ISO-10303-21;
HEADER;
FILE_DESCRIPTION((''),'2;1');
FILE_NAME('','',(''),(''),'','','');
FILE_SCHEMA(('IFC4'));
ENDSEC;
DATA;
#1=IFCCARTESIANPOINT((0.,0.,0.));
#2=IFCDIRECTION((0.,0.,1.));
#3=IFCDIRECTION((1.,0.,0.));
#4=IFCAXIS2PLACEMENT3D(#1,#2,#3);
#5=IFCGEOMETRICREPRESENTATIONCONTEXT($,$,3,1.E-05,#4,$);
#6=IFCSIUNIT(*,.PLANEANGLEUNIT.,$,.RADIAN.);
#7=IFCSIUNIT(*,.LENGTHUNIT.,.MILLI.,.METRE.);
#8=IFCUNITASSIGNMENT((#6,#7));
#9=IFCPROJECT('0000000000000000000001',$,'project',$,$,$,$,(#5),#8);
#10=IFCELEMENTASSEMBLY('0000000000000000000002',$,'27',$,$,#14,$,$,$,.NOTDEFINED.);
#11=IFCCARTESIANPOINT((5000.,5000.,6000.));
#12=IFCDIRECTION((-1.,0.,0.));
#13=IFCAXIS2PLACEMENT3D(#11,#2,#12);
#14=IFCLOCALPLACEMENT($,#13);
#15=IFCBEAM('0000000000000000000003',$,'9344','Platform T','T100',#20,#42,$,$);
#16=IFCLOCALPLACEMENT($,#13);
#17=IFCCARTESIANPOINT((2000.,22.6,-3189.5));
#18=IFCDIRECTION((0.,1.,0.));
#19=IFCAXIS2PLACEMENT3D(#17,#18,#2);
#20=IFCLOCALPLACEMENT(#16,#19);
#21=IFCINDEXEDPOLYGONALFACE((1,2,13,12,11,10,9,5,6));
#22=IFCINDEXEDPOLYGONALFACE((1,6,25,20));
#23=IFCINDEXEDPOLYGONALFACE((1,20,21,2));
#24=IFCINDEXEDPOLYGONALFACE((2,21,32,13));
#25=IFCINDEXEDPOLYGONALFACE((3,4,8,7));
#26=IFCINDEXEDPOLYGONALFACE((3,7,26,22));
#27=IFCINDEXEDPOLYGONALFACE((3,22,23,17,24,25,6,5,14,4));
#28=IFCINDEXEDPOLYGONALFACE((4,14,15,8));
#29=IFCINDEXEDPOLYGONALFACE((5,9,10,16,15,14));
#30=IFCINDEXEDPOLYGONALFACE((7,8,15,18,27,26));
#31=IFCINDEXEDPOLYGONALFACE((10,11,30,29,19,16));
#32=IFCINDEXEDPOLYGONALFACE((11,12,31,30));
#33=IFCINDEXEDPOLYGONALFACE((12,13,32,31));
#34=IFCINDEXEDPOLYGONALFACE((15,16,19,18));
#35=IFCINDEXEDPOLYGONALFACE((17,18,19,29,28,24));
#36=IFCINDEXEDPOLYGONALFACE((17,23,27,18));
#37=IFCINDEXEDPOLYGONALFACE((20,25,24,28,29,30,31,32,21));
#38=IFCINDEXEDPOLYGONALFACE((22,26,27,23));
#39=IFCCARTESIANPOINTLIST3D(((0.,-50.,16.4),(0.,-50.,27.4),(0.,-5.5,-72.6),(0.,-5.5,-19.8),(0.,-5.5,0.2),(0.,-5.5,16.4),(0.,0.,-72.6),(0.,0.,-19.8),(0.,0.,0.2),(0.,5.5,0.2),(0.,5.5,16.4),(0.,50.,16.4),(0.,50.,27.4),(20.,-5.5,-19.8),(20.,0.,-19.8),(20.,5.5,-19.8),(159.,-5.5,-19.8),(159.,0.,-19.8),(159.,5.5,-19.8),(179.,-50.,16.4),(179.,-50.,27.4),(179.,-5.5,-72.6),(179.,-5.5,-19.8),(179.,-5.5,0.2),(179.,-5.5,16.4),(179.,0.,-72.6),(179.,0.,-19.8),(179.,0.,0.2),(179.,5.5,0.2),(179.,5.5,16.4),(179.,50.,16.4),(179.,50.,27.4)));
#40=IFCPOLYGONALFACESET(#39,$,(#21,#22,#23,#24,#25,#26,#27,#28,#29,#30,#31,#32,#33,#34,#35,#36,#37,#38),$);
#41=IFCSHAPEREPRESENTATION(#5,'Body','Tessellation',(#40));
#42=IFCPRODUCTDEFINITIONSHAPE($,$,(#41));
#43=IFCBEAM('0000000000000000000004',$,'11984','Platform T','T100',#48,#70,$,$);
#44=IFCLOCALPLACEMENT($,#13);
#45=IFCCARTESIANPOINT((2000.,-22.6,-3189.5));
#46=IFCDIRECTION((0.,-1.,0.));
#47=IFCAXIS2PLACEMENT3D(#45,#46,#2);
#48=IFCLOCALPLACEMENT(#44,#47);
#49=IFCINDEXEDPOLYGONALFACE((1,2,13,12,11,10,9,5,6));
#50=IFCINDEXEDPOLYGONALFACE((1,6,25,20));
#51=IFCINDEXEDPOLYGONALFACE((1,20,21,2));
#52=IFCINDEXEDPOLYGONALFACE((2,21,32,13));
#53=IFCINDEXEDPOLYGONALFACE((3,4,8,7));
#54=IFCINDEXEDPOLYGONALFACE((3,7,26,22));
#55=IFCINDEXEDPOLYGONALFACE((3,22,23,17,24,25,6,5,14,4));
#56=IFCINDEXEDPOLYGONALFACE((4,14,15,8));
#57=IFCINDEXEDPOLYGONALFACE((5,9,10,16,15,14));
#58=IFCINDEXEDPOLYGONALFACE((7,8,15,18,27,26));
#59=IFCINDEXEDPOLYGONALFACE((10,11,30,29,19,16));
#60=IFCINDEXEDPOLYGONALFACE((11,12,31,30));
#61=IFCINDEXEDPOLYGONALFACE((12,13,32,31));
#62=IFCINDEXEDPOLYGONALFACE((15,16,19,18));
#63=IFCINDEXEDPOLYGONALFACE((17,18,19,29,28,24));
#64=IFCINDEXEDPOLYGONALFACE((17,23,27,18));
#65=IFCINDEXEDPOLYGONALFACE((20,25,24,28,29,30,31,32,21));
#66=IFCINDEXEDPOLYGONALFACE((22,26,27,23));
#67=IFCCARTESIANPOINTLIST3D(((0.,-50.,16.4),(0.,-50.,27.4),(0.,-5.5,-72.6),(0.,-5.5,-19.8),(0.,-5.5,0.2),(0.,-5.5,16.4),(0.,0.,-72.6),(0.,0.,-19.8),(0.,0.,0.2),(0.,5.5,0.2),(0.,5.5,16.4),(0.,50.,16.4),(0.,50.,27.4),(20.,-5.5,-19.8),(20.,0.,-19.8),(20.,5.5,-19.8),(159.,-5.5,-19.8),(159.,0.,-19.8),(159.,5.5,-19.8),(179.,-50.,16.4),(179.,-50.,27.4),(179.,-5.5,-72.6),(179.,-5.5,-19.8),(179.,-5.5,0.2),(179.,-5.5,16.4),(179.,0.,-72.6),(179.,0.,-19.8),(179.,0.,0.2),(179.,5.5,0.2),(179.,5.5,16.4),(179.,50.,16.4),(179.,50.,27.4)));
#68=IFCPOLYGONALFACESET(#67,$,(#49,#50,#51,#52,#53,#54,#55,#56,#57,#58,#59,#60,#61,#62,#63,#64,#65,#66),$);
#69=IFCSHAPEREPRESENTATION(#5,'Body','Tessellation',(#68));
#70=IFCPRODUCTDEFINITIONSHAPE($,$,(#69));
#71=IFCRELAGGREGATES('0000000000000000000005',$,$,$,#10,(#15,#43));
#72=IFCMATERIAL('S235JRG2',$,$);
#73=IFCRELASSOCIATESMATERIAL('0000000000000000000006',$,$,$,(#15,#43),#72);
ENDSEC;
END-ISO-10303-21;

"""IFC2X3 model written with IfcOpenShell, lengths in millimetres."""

from ifc_helpers import new_model, si_unit, point, frame, origin_with_axes, place, context, project, polyline, line_curve, trimmed, segment, composite_curve, outline, extrude, material, element, aggregate, save


model = new_model("IFC2X3")

# Units and contexts
context_of_model = context(None, 3, precision=1e-05, world=origin_with_axes())
ifc_project = project(units=[si_unit("PLANEANGLEUNIT", "RADIAN"), si_unit("LENGTHUNIT", "METRE", prefix="MILLI")], contexts=[context_of_model])

# Shared definitions
ifc_material = material(Name="S235JRG2")

# Element assembly, beams, openings
assembly_1_placement = place(None, frame((5000.0, 5000.0, 6000.0), z_axis=(0.0, 0.0, 1.0), x_axis=(-1.0, 0.0, 0.0)))
assembly_1 = element("IfcElementAssembly", 1, at=assembly_1_placement, Name="27", PredefinedType="NOTDEFINED")
placement_1 = place(None, frame((5000.0, 5000.0, 6000.0), z_axis=(0.0, 0.0, 1.0), x_axis=(-1.0, 0.0, 0.0)))
beam_1_placement = place(placement_1, frame((2000.0, 22.6, -3189.5), z_axis=(0.0, 1.0, 0.0), x_axis=(0.0, 0.0, 1.0)))
beam_1 = element("IfcBeam", 2, at=beam_1_placement, material=ifc_material, Name="9344", Description="Platform T", ObjectType="T100", context=context_of_model, shape_type="SweptSolid", body=[
    extrude(outline(polyline([(5.5, -72.6), (5.5, 16.4), (50.0, 16.4), (50.0, 27.4), (-50.0, 27.4), (-50.0, 16.4), (-5.5, 16.4), (-5.5, -72.6), (5.5, -72.6), (5.5, -72.6)])), frame((0.0, 0.0, 0.0), z_axis=(1.0, 0.0, 0.0), x_axis=(0.0, 1.0, 0.0)), (0.0, 0.0, 1.0), 179.0),
])
opening_1_placement = place(beam_1_placement, frame((179.0, 0.0, -72.6), z_axis=(0.0, 1.0, 0.0), x_axis=(0.0, 0.0, 1.0)))
element("IfcOpeningElement", 3, at=opening_1_placement, cuts=beam_1, ObjectType="Recess", context=context_of_model, shape_type="SweptSolid", body=[
    extrude(outline(composite_curve([segment(trimmed(line_curve((0.0, 0.0), (0.0, -1.0, 0.0), 179.0), [point((0.0, 0.0))], [point((0.0, -179.0))], True, "CARTESIAN"), True, "CONTINUOUS"), segment(trimmed(line_curve((0.0, -179.0), (1.0, 0.0, 0.0), 52.8), [point((0.0, -179.0))], [point((52.8, -179.0))], True, "CARTESIAN"), True, "CONTINUOUS"), segment(trimmed(line_curve((52.8, -179.0), (0.0, 1.0, 0.0), 179.0), [point((52.8, -179.0))], [point((52.8, 0.0))], True, "CARTESIAN"), True, "CONTINUOUS"), segment(trimmed(line_curve((52.8, 0.0), (-1.0, 0.0, 0.0), 52.8), [point((52.8, 0.0))], [point((0.0, 0.0))], True, "CARTESIAN"), True, "CONTINUOUS")], self_intersect=False)), origin_with_axes(), (0.0, 0.0, 1.0), 100.0),
])
opening_2_placement = place(beam_1_placement, frame((179.0, 0.0, -19.8), z_axis=(0.0, 1.0, 0.0), x_axis=(0.0, 0.0, 1.0)))
element("IfcOpeningElement", 4, at=opening_2_placement, cuts=beam_1, context=context_of_model, shape_type="SweptSolid", body=[
    extrude(outline(composite_curve([segment(trimmed(line_curve((0.0, 0.0), (1.0, 0.0, 0.0), 20.0), [point((0.0, 0.0))], [point((20.0, 0.0))], True, "CARTESIAN"), True, "CONTINUOUS"), segment(trimmed(line_curve((20.0, 0.0), (-0.707107, -0.707107, 0.0), 28.284271), [point((20.0, 0.0))], [point((0.0, -20.0))], True, "CARTESIAN"), True, "CONTINUOUS"), segment(trimmed(line_curve((0.0, -20.0), (0.0, 1.0, 0.0), 20.0), [point((0.0, -20.0))], [point((0.0, 0.0))], True, "CARTESIAN"), True, "CONTINUOUS")], self_intersect=False)), origin_with_axes(), (0.0, 0.0, 1.0), 100.0),
])
opening_3_placement = place(beam_1_placement, frame((179.0, 0.0, -19.8), z_axis=(0.0, -1.0, 0.0), x_axis=(0.0, 0.0, -1.0)))
element("IfcOpeningElement", 5, at=opening_3_placement, cuts=beam_1, context=context_of_model, shape_type="SweptSolid", body=[
    extrude(outline(composite_curve([segment(trimmed(line_curve((0.0, 0.0), (-1.0, 0.0, 0.0), 20.0), [point((0.0, 0.0))], [point((-20.0, 0.0))], True, "CARTESIAN"), True, "CONTINUOUS"), segment(trimmed(line_curve((-20.0, 0.0), (0.707107, -0.707107, 0.0), 28.284271), [point((-20.0, 0.0))], [point((0.0, -20.0))], True, "CARTESIAN"), True, "CONTINUOUS"), segment(trimmed(line_curve((0.0, -20.0), (0.0, 1.0, 0.0), 20.0), [point((0.0, -20.0))], [point((0.0, 0.0))], True, "CARTESIAN"), True, "CONTINUOUS")], self_intersect=False)), origin_with_axes(), (0.0, 0.0, 1.0), 100.0),
])
opening_4_placement = place(beam_1_placement, frame((0.0, 0.0, -19.8), z_axis=(0.0, -1.0, 0.0), x_axis=(0.0, 0.0, -1.0)))
element("IfcOpeningElement", 6, at=opening_4_placement, cuts=beam_1, context=context_of_model, shape_type="SweptSolid", body=[
    extrude(outline(composite_curve([segment(trimmed(line_curve((0.0, 0.0), (-1.0, 0.0, 0.0), 20.0), [point((0.0, 0.0))], [point((-20.0, 0.0))], True, "CARTESIAN"), True, "CONTINUOUS"), segment(trimmed(line_curve((-20.0, 0.0), (0.707107, 0.707107, 0.0), 28.284271), [point((-20.0, 0.0))], [point((0.0, 20.0))], True, "CARTESIAN"), True, "CONTINUOUS"), segment(trimmed(line_curve((0.0, 20.0), (0.0, -1.0, 0.0), 20.0), [point((0.0, 20.0))], [point((0.0, 0.0))], True, "CARTESIAN"), True, "CONTINUOUS")], self_intersect=False)), origin_with_axes(), (0.0, 0.0, 1.0), 100.0),
])
opening_5_placement = place(beam_1_placement, frame((0.0, 0.0, -19.8), z_axis=(0.0, 1.0, 0.0), x_axis=(0.0, 0.0, 1.0)))
element("IfcOpeningElement", 7, at=opening_5_placement, cuts=beam_1, context=context_of_model, shape_type="SweptSolid", body=[
    extrude(outline(composite_curve([segment(trimmed(line_curve((0.0, 0.0), (1.0, 0.0, 0.0), 20.0), [point((0.0, 0.0))], [point((20.0, 0.0))], True, "CARTESIAN"), True, "CONTINUOUS"), segment(trimmed(line_curve((20.0, 0.0), (-0.707107, 0.707107, 0.0), 28.284271), [point((20.0, 0.0))], [point((0.0, 20.0))], True, "CARTESIAN"), True, "CONTINUOUS"), segment(trimmed(line_curve((0.0, 20.0), (0.0, -1.0, 0.0), 20.0), [point((0.0, 20.0))], [point((0.0, 0.0))], True, "CARTESIAN"), True, "CONTINUOUS")], self_intersect=False)), origin_with_axes(), (0.0, 0.0, 1.0), 100.0),
])
placement_2 = place(None, frame((5000.0, 5000.0, 6000.0), z_axis=(0.0, 0.0, 1.0), x_axis=(-1.0, 0.0, 0.0)))
beam_2_placement = place(placement_2, frame((2000.0, -22.6, -3189.5), z_axis=(0.0, -1.0, 0.0), x_axis=(0.0, 0.0, 1.0)))
beam_2 = element("IfcBeam", 8, at=beam_2_placement, material=ifc_material, Name="11984", Description="Platform T", ObjectType="T100", context=context_of_model, shape_type="SweptSolid", body=[
    extrude(outline(polyline([(5.5, -72.6), (5.5, 16.4), (50.0, 16.4), (50.0, 27.4), (-50.0, 27.4), (-50.0, 16.4), (-5.5, 16.4), (-5.5, -72.6), (5.5, -72.6), (5.5, -72.6)])), frame((0.0, 0.0, 0.0), z_axis=(1.0, 0.0, 0.0), x_axis=(0.0, 1.0, 0.0)), (0.0, 0.0, 1.0), 179.0),
])
opening_6_placement = place(beam_2_placement, frame((179.0, 0.0, -72.6), z_axis=(0.0, 1.0, 0.0), x_axis=(0.0, 0.0, 1.0)))
element("IfcOpeningElement", 9, at=opening_6_placement, cuts=beam_2, ObjectType="Recess", context=context_of_model, shape_type="SweptSolid", body=[
    extrude(outline(composite_curve([segment(trimmed(line_curve((0.0, 0.0), (0.0, -1.0, 0.0), 179.0), [point((0.0, 0.0))], [point((0.0, -179.0))], True, "CARTESIAN"), True, "CONTINUOUS"), segment(trimmed(line_curve((0.0, -179.0), (1.0, 0.0, 0.0), 52.8), [point((0.0, -179.0))], [point((52.8, -179.0))], True, "CARTESIAN"), True, "CONTINUOUS"), segment(trimmed(line_curve((52.8, -179.0), (0.0, 1.0, 0.0), 179.0), [point((52.8, -179.0))], [point((52.8, 0.0))], True, "CARTESIAN"), True, "CONTINUOUS"), segment(trimmed(line_curve((52.8, 0.0), (-1.0, 0.0, 0.0), 52.8), [point((52.8, 0.0))], [point((0.0, 0.0))], True, "CARTESIAN"), True, "CONTINUOUS")], self_intersect=False)), origin_with_axes(), (0.0, 0.0, 1.0), 100.0),
])
opening_7_placement = place(beam_2_placement, frame((179.0, 0.0, -19.8), z_axis=(0.0, 1.0, 0.0), x_axis=(0.0, 0.0, 1.0)))
element("IfcOpeningElement", 10, at=opening_7_placement, cuts=beam_2, context=context_of_model, shape_type="SweptSolid", body=[
    extrude(outline(composite_curve([segment(trimmed(line_curve((0.0, 0.0), (1.0, 0.0, 0.0), 20.0), [point((0.0, 0.0))], [point((20.0, 0.0))], True, "CARTESIAN"), True, "CONTINUOUS"), segment(trimmed(line_curve((20.0, 0.0), (-0.707107, -0.707107, 0.0), 28.284271), [point((20.0, 0.0))], [point((0.0, -20.0))], True, "CARTESIAN"), True, "CONTINUOUS"), segment(trimmed(line_curve((0.0, -20.0), (0.0, 1.0, 0.0), 20.0), [point((0.0, -20.0))], [point((0.0, 0.0))], True, "CARTESIAN"), True, "CONTINUOUS")], self_intersect=False)), origin_with_axes(), (0.0, 0.0, 1.0), 100.0),
])
opening_8_placement = place(beam_2_placement, frame((179.0, 0.0, -19.8), z_axis=(0.0, -1.0, 0.0), x_axis=(0.0, 0.0, -1.0)))
element("IfcOpeningElement", 11, at=opening_8_placement, cuts=beam_2, context=context_of_model, shape_type="SweptSolid", body=[
    extrude(outline(composite_curve([segment(trimmed(line_curve((0.0, 0.0), (-1.0, 0.0, 0.0), 20.0), [point((0.0, 0.0))], [point((-20.0, 0.0))], True, "CARTESIAN"), True, "CONTINUOUS"), segment(trimmed(line_curve((-20.0, 0.0), (0.707107, -0.707107, 0.0), 28.284271), [point((-20.0, 0.0))], [point((0.0, -20.0))], True, "CARTESIAN"), True, "CONTINUOUS"), segment(trimmed(line_curve((0.0, -20.0), (0.0, 1.0, 0.0), 20.0), [point((0.0, -20.0))], [point((0.0, 0.0))], True, "CARTESIAN"), True, "CONTINUOUS")], self_intersect=False)), origin_with_axes(), (0.0, 0.0, 1.0), 100.0),
])
opening_9_placement = place(beam_2_placement, frame((0.0, 0.0, -19.8), z_axis=(0.0, -1.0, 0.0), x_axis=(0.0, 0.0, -1.0)))
element("IfcOpeningElement", 12, at=opening_9_placement, cuts=beam_2, context=context_of_model, shape_type="SweptSolid", body=[
    extrude(outline(composite_curve([segment(trimmed(line_curve((0.0, 0.0), (-1.0, 0.0, 0.0), 20.0), [point((0.0, 0.0))], [point((-20.0, 0.0))], True, "CARTESIAN"), True, "CONTINUOUS"), segment(trimmed(line_curve((-20.0, 0.0), (0.707107, 0.707107, 0.0), 28.284271), [point((-20.0, 0.0))], [point((0.0, 20.0))], True, "CARTESIAN"), True, "CONTINUOUS"), segment(trimmed(line_curve((0.0, 20.0), (0.0, -1.0, 0.0), 20.0), [point((0.0, 20.0))], [point((0.0, 0.0))], True, "CARTESIAN"), True, "CONTINUOUS")], self_intersect=False)), origin_with_axes(), (0.0, 0.0, 1.0), 100.0),
])
opening_10_placement = place(beam_2_placement, frame((0.0, 0.0, -19.8), z_axis=(0.0, 1.0, 0.0), x_axis=(0.0, 0.0, 1.0)))
element("IfcOpeningElement", 13, at=opening_10_placement, cuts=beam_2, context=context_of_model, shape_type="SweptSolid", body=[
    extrude(outline(composite_curve([segment(trimmed(line_curve((0.0, 0.0), (1.0, 0.0, 0.0), 20.0), [point((0.0, 0.0))], [point((20.0, 0.0))], True, "CARTESIAN"), True, "CONTINUOUS"), segment(trimmed(line_curve((20.0, 0.0), (-0.707107, 0.707107, 0.0), 28.284271), [point((20.0, 0.0))], [point((0.0, 20.0))], True, "CARTESIAN"), True, "CONTINUOUS"), segment(trimmed(line_curve((0.0, 20.0), (0.0, -1.0, 0.0), 20.0), [point((0.0, 20.0))], [point((0.0, 0.0))], True, "CARTESIAN"), True, "CONTINUOUS")], self_intersect=False)), origin_with_axes(), (0.0, 0.0, 1.0), 100.0),
])
aggregate(assembly_1, [beam_1, beam_2])

save(model, "model.ifc")
